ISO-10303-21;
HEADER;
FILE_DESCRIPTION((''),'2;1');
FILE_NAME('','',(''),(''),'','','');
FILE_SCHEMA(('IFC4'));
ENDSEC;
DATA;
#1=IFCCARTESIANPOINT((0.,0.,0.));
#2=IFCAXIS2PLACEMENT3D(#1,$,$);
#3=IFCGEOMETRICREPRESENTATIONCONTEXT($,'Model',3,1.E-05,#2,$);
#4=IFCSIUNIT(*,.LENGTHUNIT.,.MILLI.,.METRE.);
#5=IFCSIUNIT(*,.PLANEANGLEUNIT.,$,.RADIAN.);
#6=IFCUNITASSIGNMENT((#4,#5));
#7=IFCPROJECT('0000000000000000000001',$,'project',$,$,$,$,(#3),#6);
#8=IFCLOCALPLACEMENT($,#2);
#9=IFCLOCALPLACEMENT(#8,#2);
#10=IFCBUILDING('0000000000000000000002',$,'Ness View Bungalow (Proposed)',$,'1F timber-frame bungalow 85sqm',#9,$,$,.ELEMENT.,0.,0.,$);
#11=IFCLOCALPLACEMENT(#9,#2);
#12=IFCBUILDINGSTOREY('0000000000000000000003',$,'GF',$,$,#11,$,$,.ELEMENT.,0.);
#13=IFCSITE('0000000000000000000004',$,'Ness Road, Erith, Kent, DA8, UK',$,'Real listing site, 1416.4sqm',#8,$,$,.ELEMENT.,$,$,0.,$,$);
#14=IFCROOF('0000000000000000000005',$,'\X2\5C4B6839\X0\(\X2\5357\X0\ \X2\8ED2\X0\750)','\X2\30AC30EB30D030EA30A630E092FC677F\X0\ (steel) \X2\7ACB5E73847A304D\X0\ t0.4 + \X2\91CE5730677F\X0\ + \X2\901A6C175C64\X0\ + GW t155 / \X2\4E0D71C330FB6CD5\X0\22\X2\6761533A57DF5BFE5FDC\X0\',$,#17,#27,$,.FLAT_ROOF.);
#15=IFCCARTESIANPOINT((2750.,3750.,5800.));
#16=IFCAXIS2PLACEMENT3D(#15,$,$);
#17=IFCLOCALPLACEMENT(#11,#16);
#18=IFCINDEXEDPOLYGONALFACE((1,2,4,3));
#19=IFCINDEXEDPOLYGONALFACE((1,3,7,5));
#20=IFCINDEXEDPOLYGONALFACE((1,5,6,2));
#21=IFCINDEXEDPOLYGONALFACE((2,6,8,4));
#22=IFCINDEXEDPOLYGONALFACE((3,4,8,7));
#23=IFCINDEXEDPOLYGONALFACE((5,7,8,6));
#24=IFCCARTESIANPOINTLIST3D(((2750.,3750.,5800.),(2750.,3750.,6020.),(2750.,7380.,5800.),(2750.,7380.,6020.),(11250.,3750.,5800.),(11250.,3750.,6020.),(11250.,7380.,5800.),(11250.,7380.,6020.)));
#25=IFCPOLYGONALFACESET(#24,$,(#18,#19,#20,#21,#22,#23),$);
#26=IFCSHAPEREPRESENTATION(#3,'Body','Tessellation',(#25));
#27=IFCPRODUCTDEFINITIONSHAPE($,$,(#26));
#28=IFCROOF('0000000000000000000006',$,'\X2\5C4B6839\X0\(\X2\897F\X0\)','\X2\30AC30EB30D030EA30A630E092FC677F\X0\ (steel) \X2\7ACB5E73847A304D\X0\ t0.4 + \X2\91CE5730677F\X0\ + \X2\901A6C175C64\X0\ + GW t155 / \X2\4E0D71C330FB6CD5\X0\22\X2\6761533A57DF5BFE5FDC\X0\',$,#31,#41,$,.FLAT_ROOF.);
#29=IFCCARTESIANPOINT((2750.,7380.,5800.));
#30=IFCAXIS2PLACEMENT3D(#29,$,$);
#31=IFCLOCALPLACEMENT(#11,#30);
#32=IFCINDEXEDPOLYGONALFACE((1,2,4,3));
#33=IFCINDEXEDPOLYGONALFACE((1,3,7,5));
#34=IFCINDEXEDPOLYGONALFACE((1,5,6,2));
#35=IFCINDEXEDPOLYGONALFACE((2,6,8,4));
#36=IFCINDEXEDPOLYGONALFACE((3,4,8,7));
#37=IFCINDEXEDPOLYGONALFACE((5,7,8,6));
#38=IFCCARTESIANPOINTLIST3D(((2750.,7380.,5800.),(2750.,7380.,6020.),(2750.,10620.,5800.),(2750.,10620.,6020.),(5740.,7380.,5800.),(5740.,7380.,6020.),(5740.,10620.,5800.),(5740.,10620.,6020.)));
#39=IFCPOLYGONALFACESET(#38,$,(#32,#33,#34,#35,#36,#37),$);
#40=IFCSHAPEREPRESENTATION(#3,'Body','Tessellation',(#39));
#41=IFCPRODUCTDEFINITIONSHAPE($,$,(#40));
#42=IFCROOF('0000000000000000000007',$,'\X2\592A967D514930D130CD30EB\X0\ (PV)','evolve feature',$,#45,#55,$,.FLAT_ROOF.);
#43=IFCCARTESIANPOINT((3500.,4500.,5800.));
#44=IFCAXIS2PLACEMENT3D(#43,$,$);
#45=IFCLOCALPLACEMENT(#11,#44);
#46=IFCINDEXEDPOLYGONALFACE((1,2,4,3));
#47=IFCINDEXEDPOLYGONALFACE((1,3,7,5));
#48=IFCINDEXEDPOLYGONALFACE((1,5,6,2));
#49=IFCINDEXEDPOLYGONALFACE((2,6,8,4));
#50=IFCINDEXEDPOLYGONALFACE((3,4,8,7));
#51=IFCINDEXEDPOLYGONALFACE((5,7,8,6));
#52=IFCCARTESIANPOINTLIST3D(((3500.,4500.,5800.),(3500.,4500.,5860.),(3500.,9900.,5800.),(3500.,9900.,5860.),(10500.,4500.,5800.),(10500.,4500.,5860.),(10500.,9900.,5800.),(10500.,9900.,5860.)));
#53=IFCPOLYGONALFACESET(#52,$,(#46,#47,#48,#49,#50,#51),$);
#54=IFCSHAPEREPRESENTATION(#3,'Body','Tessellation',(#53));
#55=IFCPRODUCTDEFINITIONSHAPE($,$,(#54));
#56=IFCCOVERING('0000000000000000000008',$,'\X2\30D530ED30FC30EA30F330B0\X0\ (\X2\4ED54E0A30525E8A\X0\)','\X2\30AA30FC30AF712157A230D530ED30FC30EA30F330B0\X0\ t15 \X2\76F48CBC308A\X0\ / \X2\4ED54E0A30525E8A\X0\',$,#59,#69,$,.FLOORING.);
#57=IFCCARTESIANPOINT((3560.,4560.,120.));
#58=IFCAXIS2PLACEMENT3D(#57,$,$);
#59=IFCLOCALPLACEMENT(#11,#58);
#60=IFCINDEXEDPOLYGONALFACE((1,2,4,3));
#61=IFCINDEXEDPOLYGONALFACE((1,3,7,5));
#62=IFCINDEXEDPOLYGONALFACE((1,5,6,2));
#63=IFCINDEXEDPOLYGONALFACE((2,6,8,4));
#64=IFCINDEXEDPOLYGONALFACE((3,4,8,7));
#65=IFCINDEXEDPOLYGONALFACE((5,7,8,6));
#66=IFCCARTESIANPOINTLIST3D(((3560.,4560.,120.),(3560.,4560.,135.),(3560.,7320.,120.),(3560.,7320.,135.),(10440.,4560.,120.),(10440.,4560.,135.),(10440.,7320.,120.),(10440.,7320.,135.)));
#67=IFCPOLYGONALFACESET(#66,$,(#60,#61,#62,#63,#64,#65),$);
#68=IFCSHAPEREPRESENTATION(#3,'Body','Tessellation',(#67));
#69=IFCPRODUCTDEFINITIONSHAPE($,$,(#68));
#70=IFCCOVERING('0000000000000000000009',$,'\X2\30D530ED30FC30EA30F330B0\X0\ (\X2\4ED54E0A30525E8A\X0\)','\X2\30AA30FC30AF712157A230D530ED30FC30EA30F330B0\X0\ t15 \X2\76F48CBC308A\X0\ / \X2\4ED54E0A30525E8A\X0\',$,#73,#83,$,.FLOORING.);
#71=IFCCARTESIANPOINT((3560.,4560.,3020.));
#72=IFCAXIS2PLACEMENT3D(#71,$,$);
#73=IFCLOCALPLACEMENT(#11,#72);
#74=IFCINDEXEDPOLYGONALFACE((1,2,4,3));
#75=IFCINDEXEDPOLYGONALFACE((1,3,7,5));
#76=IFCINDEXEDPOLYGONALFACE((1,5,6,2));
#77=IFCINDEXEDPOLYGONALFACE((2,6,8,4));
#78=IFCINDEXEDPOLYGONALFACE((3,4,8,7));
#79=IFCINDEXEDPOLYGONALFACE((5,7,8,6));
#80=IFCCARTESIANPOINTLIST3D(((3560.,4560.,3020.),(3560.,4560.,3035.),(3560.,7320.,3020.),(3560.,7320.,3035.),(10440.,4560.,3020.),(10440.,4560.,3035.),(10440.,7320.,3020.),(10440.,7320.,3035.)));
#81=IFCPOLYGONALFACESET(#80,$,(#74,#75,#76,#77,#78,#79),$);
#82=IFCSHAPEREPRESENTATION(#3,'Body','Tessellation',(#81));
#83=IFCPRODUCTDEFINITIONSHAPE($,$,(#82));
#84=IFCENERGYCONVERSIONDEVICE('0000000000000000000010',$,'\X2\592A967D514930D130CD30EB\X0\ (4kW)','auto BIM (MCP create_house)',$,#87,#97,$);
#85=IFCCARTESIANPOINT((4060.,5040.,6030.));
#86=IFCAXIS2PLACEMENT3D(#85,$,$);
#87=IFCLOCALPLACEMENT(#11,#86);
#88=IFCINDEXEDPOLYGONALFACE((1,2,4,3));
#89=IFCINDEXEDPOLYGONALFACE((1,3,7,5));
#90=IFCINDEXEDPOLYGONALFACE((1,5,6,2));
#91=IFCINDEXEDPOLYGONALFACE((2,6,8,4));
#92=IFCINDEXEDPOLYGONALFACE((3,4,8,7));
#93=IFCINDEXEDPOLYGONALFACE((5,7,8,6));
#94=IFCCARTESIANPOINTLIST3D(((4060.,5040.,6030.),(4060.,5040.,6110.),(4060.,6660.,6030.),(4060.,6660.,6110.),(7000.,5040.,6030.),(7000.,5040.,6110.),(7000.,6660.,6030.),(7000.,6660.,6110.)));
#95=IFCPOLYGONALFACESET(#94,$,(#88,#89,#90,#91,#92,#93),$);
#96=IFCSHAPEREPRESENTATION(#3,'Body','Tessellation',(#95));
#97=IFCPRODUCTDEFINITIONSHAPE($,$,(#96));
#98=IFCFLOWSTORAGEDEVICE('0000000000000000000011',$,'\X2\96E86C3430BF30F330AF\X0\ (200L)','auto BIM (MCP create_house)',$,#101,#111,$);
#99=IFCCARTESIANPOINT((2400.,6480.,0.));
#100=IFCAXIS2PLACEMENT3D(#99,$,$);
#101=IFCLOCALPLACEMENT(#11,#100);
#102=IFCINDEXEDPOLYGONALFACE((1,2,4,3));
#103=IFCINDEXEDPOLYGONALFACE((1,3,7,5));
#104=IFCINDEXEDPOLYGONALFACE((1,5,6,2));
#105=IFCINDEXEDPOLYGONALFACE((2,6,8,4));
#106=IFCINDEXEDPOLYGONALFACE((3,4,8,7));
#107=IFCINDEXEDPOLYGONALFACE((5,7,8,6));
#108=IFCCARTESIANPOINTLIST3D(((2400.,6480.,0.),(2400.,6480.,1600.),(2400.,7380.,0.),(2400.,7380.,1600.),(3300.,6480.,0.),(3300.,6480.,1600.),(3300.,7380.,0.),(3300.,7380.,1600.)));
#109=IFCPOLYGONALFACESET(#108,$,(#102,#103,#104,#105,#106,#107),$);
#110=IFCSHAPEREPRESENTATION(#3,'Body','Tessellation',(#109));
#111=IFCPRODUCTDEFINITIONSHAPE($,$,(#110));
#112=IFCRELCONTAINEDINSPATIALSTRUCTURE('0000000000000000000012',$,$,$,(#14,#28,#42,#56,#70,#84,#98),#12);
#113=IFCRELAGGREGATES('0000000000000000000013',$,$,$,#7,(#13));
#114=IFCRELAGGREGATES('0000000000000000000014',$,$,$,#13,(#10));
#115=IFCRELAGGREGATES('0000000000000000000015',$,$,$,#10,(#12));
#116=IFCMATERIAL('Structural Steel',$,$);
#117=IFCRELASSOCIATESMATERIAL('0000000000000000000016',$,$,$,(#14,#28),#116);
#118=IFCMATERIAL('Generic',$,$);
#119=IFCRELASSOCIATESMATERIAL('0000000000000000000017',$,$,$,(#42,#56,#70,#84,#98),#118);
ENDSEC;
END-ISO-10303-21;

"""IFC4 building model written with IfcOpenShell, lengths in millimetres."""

from ifc_helpers import new_model, si_unit, frame, frame_2d, origin, place, context, project, spatial, rectangle, extrude, material, element, save


model = new_model("IFC4")

# Units and contexts
model_context = context("Model", 3, precision=1e-05, world=origin())
ifc_project = project(units=[si_unit("LENGTHUNIT", "METRE", prefix="MILLI"), si_unit("PLANEANGLEUNIT", "RADIAN")], contexts=[model_context])

# Site, building, storey
site_placement = place(None, origin())
site = spatial("IfcSite", under=ifc_project, at=site_placement, Name="Ness Road, Erith, Kent, DA8, UK", ObjectType="Real listing site, 1416.4sqm", CompositionType="ELEMENT", RefElevation=0.0)
building_placement = place(site_placement, origin())
building = spatial("IfcBuilding", under=site, at=building_placement, Name="Ness View Bungalow (Proposed)", ObjectType="1F timber-frame bungalow 85sqm", CompositionType="ELEMENT", ElevationOfRefHeight=0.0, ElevationOfTerrain=0.0)
storey_placement = place(building_placement, origin())
storey = spatial("IfcBuildingStorey", under=building, at=storey_placement, Name="GF", CompositionType="ELEMENT", Elevation=0.0)

# Shared definitions
ifc_material_1 = material(Name="Generic")

# Roofs
ifc_material_2 = material(Name="Structural Steel")
roof_1_placement = place(storey_placement, frame((2750.0, 3750.0, 5800.0)))
element("IfcRoof", 1, at=roof_1_placement, inside=storey, material=ifc_material_2, Name="屋根(南 軒750)", Description="ガルバリウム鋼板 (steel) 立平葺き t0.4 + 野地板 + 通気層 + GW t155 / 不燃・法22条区域対応", PredefinedType="FLAT_ROOF", context=model_context, shape_type="SweptSolid", body=[
    extrude(rectangle(XDim=8500.0, YDim=3630.0, at=frame_2d((4250.0, 1815.0))), frame((2750.0, 3750.0, 5800.0)), (0.0, 0.0, 1.0), 220.0),
])
roof_2_placement = place(storey_placement, frame((2750.0, 7380.0, 5800.0)))
element("IfcRoof", 2, at=roof_2_placement, inside=storey, material=ifc_material_2, Name="屋根(西)", Description="ガルバリウム鋼板 (steel) 立平葺き t0.4 + 野地板 + 通気層 + GW t155 / 不燃・法22条区域対応", PredefinedType="FLAT_ROOF", context=model_context, shape_type="SweptSolid", body=[
    extrude(rectangle(XDim=2990.0, YDim=3240.0, at=frame_2d((1495.0, 1620.0))), frame((2750.0, 7380.0, 5800.0)), (0.0, 0.0, 1.0), 220.0),
])
roof_3_placement = place(storey_placement, frame((3500.0, 4500.0, 5800.0)))
element("IfcRoof", 3, at=roof_3_placement, inside=storey, material=ifc_material_1, Name="太陽光パネル (PV)", Description="evolve feature", PredefinedType="FLAT_ROOF", context=model_context, shape_type="SweptSolid", body=[
    extrude(rectangle(XDim=7000.0, YDim=5400.0, at=frame_2d((3500.0, 2700.0))), frame((3500.0, 4500.0, 5800.0)), (0.0, 0.0, 1.0), 60.0),
])

# Coverings
covering_1_placement = place(storey_placement, frame((3560.0, 4560.0, 120.0)))
element("IfcCovering", 4, at=covering_1_placement, inside=storey, material=ifc_material_1, Name="フローリング (仕上げ床)", Description="オーク無垢フローリング t15 直貼り / 仕上げ床", PredefinedType="FLOORING", context=model_context, shape_type="SweptSolid", body=[
    extrude(rectangle(XDim=6880.0, YDim=2760.0, at=frame_2d((3440.0, 1380.0))), frame((3560.0, 4560.0, 120.0)), (0.0, 0.0, 1.0), 15.0),
])
covering_2_placement = place(storey_placement, frame((3560.0, 4560.0, 3020.0)))
element("IfcCovering", 5, at=covering_2_placement, inside=storey, material=ifc_material_1, Name="フローリング (仕上げ床)", Description="オーク無垢フローリング t15 直貼り / 仕上げ床", PredefinedType="FLOORING", context=model_context, shape_type="SweptSolid", body=[
    extrude(rectangle(XDim=6880.0, YDim=2760.0, at=frame_2d((3440.0, 1380.0))), frame((3560.0, 4560.0, 3020.0)), (0.0, 0.0, 1.0), 15.0),
])

# Energy conversion device
energy_conversion_device_placement = place(storey_placement, frame((4060.0, 5040.0, 6030.0)))
element("IfcEnergyConversionDevice", 6, at=energy_conversion_device_placement, inside=storey, material=ifc_material_1, Name="太陽光パネル (4kW)", Description="auto BIM (MCP create_house)", context=model_context, shape_type="SweptSolid", body=[
    extrude(rectangle(XDim=2940.0, YDim=1620.0, at=frame_2d((1470.0, 810.0))), frame((4060.0, 5040.0, 6030.0)), (0.0, 0.0, 1.0), 80.0),
])

# Flow storage device
flow_storage_device_placement = place(storey_placement, frame((2400.0, 6480.0, 0.0)))
element("IfcFlowStorageDevice", 7, at=flow_storage_device_placement, inside=storey, material=ifc_material_1, Name="雨水タンク (200L)", Description="auto BIM (MCP create_house)", context=model_context, shape_type="SweptSolid", body=[
    extrude(rectangle(XDim=900.0, YDim=900.0, at=frame_2d((450.0, 450.0))), frame((2400.0, 6480.0, 0.0)), (0.0, 0.0, 1.0), 1600.0),
])

save(model, "model.ifc")
